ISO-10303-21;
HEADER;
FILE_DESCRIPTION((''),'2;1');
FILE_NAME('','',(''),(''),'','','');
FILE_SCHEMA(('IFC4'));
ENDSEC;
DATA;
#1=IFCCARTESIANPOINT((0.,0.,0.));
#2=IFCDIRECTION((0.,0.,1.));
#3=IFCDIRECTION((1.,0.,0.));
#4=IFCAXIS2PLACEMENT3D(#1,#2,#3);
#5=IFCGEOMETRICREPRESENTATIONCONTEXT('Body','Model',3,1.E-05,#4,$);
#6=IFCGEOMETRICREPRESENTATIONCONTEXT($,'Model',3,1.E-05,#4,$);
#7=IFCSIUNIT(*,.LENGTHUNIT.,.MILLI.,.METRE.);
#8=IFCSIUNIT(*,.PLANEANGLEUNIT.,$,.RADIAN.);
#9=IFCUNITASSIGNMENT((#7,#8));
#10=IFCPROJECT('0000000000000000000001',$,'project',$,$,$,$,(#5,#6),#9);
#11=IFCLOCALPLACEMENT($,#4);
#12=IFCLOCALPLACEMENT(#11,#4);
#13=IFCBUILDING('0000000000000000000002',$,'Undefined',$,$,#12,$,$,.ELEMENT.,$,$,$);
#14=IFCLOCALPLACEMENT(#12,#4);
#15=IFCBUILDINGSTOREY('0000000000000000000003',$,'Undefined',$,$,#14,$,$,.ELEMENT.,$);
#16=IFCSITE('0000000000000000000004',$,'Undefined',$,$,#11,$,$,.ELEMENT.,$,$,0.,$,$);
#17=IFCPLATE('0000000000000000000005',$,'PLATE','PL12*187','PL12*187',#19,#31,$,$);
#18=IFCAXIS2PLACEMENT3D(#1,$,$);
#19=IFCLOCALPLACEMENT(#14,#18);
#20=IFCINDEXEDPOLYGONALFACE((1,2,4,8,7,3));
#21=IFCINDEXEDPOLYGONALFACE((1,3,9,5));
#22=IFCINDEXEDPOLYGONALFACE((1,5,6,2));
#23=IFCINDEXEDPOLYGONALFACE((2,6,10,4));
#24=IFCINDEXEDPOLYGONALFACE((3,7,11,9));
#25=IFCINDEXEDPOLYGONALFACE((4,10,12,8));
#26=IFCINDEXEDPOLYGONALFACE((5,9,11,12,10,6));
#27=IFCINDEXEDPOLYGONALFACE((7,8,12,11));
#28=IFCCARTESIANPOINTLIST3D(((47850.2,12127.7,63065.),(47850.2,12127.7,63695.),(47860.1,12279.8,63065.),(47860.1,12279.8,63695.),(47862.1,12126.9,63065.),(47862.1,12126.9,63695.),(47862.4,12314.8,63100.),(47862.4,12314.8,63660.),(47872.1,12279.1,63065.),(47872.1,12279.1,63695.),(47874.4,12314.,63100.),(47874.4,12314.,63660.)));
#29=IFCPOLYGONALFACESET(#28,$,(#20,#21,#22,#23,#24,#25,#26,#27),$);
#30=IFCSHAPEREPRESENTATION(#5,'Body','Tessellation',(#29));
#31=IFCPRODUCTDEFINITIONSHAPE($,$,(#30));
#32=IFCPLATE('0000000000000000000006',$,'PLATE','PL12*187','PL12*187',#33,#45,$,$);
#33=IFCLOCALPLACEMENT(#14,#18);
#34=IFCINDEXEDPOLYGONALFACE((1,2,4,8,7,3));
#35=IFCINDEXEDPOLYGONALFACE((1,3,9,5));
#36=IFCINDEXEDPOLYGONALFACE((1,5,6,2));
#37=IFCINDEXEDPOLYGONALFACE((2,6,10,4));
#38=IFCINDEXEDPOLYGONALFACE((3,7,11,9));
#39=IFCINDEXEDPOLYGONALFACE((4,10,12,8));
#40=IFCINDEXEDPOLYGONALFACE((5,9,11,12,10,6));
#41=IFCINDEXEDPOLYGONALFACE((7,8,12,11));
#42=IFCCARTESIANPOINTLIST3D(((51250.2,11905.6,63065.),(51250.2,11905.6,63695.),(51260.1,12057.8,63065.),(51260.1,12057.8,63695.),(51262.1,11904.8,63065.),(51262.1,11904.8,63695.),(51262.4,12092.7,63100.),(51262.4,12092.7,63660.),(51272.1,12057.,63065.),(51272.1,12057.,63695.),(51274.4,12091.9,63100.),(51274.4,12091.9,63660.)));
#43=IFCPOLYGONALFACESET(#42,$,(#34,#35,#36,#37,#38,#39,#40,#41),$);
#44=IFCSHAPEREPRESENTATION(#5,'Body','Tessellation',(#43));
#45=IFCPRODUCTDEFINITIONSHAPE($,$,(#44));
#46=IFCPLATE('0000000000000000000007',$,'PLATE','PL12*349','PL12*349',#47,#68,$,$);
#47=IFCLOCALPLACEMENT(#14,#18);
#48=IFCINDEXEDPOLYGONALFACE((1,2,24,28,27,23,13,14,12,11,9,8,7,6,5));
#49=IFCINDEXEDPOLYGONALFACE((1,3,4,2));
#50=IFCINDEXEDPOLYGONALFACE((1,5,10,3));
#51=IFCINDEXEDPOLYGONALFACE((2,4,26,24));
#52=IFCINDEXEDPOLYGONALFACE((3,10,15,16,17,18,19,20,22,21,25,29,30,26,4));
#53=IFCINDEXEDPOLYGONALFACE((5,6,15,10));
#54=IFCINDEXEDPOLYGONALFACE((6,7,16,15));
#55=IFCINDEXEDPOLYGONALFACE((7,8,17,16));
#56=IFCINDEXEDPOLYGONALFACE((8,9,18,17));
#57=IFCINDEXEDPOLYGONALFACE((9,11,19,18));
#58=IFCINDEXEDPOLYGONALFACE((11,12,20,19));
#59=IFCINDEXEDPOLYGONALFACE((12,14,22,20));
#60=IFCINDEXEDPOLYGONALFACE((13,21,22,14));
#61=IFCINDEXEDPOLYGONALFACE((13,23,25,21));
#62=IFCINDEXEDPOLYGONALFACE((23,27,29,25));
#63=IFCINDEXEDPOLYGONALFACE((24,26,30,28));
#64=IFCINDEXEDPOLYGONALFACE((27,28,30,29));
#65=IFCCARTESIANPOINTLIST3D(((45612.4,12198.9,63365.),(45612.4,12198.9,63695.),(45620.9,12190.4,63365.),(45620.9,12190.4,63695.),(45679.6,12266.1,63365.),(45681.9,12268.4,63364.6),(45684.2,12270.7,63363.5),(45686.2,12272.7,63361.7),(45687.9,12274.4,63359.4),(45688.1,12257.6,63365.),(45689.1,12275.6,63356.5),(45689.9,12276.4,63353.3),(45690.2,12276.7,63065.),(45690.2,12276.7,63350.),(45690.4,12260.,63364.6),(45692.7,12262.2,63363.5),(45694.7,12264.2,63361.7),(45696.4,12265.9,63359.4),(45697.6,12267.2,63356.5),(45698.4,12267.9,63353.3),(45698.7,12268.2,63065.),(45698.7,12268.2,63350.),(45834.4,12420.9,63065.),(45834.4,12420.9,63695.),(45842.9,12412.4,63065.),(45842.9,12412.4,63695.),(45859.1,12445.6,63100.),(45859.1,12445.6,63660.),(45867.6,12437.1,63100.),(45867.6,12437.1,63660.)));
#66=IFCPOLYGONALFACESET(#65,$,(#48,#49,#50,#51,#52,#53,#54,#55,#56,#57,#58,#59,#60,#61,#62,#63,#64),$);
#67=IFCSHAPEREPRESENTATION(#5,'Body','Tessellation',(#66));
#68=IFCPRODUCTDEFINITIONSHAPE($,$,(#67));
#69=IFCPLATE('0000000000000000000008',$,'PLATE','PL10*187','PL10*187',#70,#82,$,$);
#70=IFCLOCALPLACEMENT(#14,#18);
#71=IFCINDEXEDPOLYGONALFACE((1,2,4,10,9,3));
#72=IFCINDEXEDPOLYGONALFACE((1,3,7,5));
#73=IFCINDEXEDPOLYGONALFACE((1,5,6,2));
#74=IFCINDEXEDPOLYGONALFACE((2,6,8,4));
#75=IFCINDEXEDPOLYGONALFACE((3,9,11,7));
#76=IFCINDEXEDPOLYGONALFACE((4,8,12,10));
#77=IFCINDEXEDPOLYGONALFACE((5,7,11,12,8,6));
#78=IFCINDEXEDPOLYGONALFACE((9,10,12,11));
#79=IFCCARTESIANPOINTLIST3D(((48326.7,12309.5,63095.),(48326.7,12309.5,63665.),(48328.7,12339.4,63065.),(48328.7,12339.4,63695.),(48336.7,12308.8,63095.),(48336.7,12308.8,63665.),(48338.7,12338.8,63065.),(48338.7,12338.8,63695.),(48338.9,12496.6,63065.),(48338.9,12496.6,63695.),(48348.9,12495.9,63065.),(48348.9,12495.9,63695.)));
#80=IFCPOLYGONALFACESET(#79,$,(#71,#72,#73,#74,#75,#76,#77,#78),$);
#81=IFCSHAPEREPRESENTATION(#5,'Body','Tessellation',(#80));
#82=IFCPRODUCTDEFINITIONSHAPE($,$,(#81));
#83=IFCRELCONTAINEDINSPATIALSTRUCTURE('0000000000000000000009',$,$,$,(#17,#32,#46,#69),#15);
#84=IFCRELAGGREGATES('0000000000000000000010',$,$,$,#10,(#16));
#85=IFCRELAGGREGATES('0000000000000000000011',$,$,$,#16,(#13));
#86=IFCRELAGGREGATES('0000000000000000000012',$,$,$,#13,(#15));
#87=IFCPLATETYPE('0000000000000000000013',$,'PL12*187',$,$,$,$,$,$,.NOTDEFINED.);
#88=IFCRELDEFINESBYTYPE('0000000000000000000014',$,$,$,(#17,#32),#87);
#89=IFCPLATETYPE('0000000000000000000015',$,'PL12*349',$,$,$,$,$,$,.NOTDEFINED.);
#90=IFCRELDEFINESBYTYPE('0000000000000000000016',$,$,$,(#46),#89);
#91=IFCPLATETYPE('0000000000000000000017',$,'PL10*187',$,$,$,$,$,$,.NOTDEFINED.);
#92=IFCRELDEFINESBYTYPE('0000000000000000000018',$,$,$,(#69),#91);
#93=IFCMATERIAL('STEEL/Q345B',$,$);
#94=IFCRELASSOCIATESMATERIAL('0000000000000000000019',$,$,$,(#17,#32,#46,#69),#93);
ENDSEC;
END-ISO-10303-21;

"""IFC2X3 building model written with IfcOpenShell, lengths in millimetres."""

from ifc_helpers import new_model, si_unit, frame, origin_with_axes, place, context, project, spatial, polyline, outline, extrude, material, type_object, element, save


model = new_model("IFC2X3")

# Units and contexts
model_context_1 = context("Model", 3, precision=1e-05, world=origin_with_axes(), identifier="Body")
model_context_2 = context("Model", 3, precision=1e-05, world=origin_with_axes())
ifc_project = project(units=[si_unit("LENGTHUNIT", "METRE", prefix="MILLI"), si_unit("PLANEANGLEUNIT", "RADIAN")], contexts=[model_context_1, model_context_2])

# Site, building, storey
site_placement = place(None, origin_with_axes())
site = spatial("IfcSite", under=ifc_project, at=site_placement, Name="Undefined", CompositionType="ELEMENT", RefElevation=0.0)
building_placement = place(site_placement, origin_with_axes())
building = spatial("IfcBuilding", under=site, at=building_placement, Name="Undefined", CompositionType="ELEMENT")
storey_placement = place(building_placement, origin_with_axes())
storey = spatial("IfcBuildingStorey", under=building, at=storey_placement, Name="Undefined", CompositionType="ELEMENT")

# Shared definitions
ifc_material_1 = material(Name="STEEL/Q345B")

# Plates
plate_type_1 = type_object("IfcPlateType", Name="PL12*187", PredefinedType="NOTDEFINED")
for number, where, z_axis, x_axis, name in (
    (1, (47868.4, 12314.4, 63065.0), (-0.997873, 0.065184, 0.0), (-0.065183, -0.997873, 0.0), "PLATE"),
    (2, (51268.4, 12092.3, 63065.0), (-0.997873, 0.065184, 0.0), (-0.065183, -0.997873, 0.0), "PLATE"),
):
    element("IfcPlate", number, at=place(storey_placement, frame(where, z_axis=z_axis, x_axis=x_axis)), inside=storey, type_object=plate_type_1, material=ifc_material_1, Name=name, Description="PL12*187", ObjectType="PL12*187", context=model_context_1, shape_type="SweptSolid", body=[
        extrude(outline(polyline([(0.0, 35.0), (35.0, 0.0), (187.5, 0.0), (187.5, 630.0), (35.0, 630.0), (0.0, 595.0), (0.0, 35.0)])), frame((0.0, 0.0, -6.0), z_axis=(0.0, 0.0, 1.0), x_axis=(1.0, 0.0, 0.0)), (0.0, 0.0, 1.0), 12.0),
    ])
plate_type_2 = type_object("IfcPlateType", Name="PL12*349", PredefinedType="NOTDEFINED")
plate_1_placement = place(storey_placement, frame((45616.6, 12194.6, 63695.0), z_axis=(0.707107, -0.707107, 0.0), x_axis=(0.0, 0.0, -1.0)))
element("IfcPlate", 3, at=plate_1_placement, inside=storey, type_object=plate_type_2, material=ifc_material_1, Name="PLATE", Description="PL12*349", ObjectType="PL12*349", context=model_context_1, shape_type="SweptSolid", body=[
    extrude(outline(polyline([(0.0, 0.0), (330.0, 0.0), (330.0, 95.0), (330.4, 98.4), (331.5, 101.5), (333.3, 104.4), (335.6, 106.8), (338.5, 108.5), (341.7, 109.7), (345.0, 110.0), (630.0, 110.0), (630.0, 313.9), (595.0, 348.9), (35.0, 348.9), (0.0, 313.9), (0.0, 0.0)])), frame((0.0, 0.0, -6.0), z_axis=(0.0, 0.0, 1.0), x_axis=(1.0, 0.0, 0.0)), (0.0, 0.0, 1.0), 12.0),
])
plate_type_3 = type_object("IfcPlateType", Name="PL10*187", PredefinedType="NOTDEFINED")
plate_2_placement = place(storey_placement, frame((48331.7, 12309.2, 63065.0), z_axis=(0.997873, -0.065183, 0.0), x_axis=(0.065184, 0.997873, 0.0)))
element("IfcPlate", 4, at=plate_2_placement, inside=storey, type_object=plate_type_3, material=ifc_material_1, Name="PLATE", Description="PL10*187", ObjectType="PL10*187", context=model_context_1, shape_type="SweptSolid", body=[
    extrude(outline(polyline([(0.0, 30.0), (30.0, 0.0), (187.5, 0.0), (187.5, 630.0), (30.0, 630.0), (0.0, 600.0), (0.0, 30.0)])), frame((0.0, 0.0, -5.0), z_axis=(0.0, 0.0, 1.0), x_axis=(1.0, 0.0, 0.0)), (0.0, 0.0, 1.0), 10.0),
])

save(model, "model.ifc")
